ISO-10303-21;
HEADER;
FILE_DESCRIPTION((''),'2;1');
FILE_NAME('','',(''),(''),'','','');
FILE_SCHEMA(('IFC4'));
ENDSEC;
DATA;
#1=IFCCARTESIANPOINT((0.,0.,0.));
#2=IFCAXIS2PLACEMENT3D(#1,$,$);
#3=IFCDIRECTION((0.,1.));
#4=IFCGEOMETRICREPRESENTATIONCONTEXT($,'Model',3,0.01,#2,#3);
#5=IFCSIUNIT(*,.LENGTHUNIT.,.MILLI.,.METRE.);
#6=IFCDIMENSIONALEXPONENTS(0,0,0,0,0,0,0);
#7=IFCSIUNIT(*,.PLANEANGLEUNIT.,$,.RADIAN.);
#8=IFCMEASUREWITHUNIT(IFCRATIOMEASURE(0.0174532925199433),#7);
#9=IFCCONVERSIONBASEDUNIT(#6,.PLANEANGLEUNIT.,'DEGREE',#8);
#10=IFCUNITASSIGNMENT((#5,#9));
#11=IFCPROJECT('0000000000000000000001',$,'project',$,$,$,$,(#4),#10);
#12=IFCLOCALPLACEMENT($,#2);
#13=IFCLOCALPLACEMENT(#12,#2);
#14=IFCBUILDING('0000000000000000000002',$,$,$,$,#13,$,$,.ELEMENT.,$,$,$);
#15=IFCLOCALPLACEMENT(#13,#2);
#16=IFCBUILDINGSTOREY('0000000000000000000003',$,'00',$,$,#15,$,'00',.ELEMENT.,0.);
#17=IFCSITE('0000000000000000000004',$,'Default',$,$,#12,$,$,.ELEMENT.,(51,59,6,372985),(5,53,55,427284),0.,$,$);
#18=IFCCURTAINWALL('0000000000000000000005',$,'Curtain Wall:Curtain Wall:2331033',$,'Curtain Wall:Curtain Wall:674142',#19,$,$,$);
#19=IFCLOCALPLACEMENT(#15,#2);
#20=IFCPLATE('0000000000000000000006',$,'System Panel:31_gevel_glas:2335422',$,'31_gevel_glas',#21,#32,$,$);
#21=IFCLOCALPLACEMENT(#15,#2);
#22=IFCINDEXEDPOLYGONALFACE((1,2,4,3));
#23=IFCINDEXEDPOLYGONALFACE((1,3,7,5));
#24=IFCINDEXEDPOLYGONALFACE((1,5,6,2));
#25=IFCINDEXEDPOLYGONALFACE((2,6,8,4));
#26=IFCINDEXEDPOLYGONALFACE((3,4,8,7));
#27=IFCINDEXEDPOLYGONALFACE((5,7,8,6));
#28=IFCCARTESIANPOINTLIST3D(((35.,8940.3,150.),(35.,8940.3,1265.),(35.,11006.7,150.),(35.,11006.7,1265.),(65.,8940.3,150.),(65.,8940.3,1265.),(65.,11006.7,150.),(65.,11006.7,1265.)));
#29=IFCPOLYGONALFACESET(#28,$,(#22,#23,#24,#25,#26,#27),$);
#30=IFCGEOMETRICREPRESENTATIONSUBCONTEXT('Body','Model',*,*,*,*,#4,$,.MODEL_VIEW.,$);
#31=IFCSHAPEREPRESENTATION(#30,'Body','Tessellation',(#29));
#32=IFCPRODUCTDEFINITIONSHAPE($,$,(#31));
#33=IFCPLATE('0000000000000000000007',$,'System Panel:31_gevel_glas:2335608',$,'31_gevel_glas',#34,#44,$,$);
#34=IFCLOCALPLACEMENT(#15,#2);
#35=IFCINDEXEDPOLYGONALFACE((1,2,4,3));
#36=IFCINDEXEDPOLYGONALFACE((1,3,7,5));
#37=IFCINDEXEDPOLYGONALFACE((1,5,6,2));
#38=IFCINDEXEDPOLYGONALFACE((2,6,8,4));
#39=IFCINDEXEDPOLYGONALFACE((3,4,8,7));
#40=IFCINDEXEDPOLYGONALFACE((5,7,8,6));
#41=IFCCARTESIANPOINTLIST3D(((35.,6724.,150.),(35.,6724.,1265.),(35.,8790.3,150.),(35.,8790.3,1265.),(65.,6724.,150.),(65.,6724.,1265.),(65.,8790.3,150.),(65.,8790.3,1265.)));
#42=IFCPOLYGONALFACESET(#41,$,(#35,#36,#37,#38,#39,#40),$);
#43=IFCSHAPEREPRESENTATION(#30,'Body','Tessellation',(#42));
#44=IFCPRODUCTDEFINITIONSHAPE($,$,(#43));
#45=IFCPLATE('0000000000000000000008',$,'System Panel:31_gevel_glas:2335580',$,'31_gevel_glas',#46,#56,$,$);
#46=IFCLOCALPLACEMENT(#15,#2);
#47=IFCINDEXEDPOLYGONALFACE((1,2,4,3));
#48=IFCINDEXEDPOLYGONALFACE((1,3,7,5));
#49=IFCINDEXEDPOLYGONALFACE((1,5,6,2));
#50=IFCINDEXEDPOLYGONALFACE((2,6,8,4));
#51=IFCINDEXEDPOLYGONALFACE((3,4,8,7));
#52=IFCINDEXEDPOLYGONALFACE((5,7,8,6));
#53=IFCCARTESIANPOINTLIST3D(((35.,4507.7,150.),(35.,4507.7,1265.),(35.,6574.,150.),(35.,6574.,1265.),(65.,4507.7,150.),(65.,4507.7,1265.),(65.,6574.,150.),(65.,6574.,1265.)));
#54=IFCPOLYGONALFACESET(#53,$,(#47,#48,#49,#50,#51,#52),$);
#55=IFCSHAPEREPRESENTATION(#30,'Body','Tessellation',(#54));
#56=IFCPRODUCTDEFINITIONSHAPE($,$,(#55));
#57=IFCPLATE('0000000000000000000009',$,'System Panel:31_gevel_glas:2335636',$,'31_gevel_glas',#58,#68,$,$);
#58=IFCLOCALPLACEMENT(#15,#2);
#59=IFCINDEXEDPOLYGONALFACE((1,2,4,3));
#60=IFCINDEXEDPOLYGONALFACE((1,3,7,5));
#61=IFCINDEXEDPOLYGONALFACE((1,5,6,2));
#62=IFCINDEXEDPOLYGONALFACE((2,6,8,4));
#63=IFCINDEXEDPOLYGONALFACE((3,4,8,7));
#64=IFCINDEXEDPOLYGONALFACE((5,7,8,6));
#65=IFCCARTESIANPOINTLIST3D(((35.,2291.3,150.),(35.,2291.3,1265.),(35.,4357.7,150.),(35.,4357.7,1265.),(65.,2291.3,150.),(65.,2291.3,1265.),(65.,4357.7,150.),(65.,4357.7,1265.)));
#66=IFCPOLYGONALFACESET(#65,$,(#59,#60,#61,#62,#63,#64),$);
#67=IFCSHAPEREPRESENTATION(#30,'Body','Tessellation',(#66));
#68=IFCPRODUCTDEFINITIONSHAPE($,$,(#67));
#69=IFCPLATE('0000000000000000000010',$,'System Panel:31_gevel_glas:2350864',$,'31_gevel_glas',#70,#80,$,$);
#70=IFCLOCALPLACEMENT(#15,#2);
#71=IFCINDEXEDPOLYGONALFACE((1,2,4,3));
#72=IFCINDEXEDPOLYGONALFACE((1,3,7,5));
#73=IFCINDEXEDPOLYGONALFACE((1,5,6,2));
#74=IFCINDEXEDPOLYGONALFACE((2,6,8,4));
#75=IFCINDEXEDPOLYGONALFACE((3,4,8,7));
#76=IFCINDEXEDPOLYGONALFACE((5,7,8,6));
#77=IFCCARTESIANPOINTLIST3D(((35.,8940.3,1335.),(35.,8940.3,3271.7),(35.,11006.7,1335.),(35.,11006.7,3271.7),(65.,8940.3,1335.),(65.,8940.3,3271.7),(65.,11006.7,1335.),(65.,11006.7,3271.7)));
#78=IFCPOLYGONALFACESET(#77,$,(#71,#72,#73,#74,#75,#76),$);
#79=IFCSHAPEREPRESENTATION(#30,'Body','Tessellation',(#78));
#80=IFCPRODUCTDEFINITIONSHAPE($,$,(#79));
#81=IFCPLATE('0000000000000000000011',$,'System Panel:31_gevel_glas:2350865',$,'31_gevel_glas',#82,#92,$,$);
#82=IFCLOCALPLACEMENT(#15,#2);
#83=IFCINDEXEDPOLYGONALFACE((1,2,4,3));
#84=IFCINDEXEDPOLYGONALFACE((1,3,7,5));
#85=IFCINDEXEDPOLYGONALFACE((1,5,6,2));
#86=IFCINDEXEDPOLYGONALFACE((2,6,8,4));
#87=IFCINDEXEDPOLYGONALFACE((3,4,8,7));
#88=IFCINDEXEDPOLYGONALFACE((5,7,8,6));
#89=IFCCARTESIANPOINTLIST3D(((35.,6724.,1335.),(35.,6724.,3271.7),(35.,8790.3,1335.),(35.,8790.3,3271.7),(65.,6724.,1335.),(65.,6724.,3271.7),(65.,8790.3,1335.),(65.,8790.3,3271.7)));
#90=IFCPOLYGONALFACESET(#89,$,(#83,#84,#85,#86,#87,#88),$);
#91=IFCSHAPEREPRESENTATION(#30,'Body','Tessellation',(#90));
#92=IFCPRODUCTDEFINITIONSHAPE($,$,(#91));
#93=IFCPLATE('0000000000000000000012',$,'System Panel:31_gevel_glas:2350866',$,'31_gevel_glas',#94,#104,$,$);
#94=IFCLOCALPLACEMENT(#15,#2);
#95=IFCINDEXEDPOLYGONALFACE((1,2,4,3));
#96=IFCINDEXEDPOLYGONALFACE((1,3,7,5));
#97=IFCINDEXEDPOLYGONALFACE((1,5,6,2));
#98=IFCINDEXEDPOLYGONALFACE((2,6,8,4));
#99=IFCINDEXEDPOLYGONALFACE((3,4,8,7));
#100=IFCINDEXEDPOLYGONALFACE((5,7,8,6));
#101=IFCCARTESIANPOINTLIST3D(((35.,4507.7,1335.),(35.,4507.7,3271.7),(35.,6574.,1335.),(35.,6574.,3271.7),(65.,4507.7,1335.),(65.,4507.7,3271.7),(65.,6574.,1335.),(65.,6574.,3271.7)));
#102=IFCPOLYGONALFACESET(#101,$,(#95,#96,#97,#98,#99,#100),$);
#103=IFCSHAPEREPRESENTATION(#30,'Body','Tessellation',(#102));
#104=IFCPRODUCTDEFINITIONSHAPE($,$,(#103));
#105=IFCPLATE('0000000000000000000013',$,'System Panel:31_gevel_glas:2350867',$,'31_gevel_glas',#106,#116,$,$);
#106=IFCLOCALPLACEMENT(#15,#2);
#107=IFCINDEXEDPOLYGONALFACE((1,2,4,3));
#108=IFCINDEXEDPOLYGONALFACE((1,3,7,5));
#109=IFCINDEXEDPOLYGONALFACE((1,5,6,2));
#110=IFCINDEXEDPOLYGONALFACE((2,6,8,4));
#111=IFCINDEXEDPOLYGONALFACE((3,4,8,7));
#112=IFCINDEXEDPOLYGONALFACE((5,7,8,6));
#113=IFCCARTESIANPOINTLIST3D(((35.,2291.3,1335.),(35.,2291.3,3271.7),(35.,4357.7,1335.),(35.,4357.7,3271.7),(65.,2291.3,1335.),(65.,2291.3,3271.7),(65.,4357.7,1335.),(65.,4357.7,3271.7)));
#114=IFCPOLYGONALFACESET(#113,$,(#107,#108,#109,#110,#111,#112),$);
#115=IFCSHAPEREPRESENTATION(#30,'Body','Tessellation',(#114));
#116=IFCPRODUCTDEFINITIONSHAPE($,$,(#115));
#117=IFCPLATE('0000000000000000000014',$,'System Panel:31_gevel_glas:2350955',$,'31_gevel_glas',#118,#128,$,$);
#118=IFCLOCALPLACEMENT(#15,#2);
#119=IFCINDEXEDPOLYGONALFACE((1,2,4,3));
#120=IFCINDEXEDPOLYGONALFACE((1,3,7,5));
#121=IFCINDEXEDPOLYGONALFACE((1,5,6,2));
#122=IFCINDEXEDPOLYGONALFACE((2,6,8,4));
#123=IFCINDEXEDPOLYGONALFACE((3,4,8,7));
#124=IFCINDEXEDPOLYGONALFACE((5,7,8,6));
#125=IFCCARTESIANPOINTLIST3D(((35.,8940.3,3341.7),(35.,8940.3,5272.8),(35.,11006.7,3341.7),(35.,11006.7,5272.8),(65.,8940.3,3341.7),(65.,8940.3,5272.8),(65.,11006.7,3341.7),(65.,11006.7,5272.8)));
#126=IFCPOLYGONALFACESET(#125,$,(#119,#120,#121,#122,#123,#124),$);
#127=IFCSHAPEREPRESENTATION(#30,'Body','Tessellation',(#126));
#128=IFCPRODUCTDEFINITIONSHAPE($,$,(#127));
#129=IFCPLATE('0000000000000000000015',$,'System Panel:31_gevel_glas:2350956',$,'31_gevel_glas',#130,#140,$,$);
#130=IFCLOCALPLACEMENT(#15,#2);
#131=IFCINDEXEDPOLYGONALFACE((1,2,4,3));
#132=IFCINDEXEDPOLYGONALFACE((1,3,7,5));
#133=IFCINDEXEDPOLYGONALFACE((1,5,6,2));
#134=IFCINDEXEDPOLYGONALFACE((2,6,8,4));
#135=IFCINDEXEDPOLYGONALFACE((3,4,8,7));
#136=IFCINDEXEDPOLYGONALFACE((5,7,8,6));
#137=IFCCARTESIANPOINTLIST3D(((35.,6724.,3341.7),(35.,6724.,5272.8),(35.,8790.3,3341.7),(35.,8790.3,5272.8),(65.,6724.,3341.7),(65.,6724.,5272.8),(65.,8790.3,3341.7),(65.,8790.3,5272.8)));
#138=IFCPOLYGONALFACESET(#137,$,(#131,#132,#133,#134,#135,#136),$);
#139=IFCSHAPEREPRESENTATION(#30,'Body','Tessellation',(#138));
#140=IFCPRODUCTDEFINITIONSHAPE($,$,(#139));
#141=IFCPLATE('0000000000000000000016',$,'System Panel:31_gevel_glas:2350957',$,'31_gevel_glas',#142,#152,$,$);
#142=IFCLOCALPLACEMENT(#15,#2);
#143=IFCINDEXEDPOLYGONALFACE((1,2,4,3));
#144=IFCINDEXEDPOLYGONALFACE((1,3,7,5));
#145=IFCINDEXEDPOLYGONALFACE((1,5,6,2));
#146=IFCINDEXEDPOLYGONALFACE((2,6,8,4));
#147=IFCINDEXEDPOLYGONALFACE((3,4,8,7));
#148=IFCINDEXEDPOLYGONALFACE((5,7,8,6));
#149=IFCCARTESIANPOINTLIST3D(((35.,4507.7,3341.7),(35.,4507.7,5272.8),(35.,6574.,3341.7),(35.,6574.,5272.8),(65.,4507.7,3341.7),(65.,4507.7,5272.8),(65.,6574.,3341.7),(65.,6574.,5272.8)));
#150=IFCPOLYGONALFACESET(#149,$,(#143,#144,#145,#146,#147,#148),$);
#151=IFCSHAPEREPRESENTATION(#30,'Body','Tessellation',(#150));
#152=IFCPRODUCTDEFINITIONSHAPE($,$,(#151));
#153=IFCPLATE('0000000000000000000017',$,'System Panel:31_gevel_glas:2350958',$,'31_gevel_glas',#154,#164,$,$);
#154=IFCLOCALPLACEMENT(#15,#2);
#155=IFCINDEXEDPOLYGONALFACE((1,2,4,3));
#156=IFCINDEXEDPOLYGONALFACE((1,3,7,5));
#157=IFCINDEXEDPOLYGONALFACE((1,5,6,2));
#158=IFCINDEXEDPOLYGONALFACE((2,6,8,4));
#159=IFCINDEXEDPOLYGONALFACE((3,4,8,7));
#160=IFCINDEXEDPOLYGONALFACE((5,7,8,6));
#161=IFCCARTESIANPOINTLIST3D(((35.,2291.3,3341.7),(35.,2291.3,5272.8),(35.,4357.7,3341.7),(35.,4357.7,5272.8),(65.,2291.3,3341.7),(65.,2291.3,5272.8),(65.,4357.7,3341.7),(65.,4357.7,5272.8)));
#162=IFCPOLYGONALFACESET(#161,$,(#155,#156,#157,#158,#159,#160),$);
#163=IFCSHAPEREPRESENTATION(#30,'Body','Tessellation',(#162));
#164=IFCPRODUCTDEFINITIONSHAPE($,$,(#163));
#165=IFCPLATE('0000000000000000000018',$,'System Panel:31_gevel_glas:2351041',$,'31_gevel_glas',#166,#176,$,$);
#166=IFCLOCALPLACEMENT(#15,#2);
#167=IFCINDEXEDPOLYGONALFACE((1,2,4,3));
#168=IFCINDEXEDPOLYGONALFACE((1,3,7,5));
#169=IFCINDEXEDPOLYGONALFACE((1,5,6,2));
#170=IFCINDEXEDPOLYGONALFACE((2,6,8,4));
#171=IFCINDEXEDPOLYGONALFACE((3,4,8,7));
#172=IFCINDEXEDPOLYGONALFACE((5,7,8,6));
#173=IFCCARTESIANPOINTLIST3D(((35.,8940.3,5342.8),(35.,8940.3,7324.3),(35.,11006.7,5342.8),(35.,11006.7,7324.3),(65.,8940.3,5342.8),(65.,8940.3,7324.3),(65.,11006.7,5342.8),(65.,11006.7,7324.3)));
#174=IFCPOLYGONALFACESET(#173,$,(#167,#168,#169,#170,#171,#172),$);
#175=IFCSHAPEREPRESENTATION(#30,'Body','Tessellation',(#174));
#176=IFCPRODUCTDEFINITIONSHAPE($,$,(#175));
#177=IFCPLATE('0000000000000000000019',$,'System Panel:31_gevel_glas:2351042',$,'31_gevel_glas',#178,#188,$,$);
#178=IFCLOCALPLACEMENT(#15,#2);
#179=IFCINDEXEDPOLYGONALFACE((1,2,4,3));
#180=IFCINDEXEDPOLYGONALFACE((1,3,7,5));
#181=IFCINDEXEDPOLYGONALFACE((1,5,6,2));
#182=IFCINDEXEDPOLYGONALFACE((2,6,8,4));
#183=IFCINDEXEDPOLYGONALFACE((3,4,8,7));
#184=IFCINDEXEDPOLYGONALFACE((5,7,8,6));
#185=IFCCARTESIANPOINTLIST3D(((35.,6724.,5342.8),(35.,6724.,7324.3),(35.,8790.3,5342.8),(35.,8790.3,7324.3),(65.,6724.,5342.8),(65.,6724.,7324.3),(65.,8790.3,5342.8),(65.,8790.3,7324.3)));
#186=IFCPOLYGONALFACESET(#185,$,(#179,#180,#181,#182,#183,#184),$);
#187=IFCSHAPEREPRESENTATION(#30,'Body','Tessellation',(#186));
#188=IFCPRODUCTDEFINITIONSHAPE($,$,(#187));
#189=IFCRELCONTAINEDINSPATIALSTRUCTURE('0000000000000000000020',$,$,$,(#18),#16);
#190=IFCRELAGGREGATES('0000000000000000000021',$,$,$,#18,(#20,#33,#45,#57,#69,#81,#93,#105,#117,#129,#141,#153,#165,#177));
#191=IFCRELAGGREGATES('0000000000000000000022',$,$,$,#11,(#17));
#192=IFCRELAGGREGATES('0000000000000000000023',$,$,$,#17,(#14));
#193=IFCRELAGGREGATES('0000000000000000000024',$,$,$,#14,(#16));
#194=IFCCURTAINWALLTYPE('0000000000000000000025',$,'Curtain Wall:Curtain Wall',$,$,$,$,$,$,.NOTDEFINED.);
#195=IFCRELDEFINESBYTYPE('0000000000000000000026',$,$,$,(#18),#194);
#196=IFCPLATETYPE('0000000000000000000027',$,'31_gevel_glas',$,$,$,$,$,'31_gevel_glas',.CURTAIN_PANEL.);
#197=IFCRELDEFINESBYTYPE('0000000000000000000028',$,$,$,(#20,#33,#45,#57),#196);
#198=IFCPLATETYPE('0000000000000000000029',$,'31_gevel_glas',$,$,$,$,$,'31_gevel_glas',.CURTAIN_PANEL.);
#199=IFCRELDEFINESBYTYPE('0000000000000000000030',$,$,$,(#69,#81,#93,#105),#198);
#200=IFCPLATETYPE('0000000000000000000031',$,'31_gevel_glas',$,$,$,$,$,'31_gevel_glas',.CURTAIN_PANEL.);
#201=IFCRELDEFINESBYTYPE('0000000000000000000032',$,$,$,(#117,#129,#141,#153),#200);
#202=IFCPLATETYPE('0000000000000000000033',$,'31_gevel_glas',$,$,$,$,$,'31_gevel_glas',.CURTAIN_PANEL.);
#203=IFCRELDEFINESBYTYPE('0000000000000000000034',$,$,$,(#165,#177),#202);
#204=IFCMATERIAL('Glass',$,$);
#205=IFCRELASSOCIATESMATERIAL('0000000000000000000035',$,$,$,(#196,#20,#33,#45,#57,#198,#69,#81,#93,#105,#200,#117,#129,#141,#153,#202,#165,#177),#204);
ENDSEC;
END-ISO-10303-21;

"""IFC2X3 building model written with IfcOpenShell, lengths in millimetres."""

from ifc_helpers import new_model, entity, si_unit, converted_unit, direction, frame, origin, origin_2d_with_axis, place, context, subcontext, project, spatial, rectangle, extrude, source, transform, mapped, material, type_object, type_shapes, element, aggregate, save


model = new_model("IFC2X3")

# Units and contexts
model_context = context("Model", 3, precision=0.01, world=origin(), true_north=direction((0.0, 1.0)))
body_context = subcontext(model_context, "Body", "Model", "MODEL_VIEW")
ifc_project = project(units=[si_unit("LENGTHUNIT", "METRE", prefix="MILLI"), converted_unit("PLANEANGLEUNIT", "DEGREE", entity("IfcRatioMeasure", 0.0174532925199433), si_unit("PLANEANGLEUNIT", "RADIAN"), dimensions=[0, 0, 0, 0, 0, 0, 0])], contexts=[model_context])

# Site, building, storey
site_placement = place(None, origin())
site = spatial("IfcSite", under=ifc_project, at=site_placement, Name="Default", CompositionType="ELEMENT", RefLatitude=(51, 59, 6, 372985), RefLongitude=(5, 53, 55, 427284), RefElevation=0.0)
building_placement = place(site_placement, origin())
building = spatial("IfcBuilding", under=site, at=building_placement, CompositionType="ELEMENT")
storey_placement = place(building_placement, origin())
storey = spatial("IfcBuildingStorey", under=building, at=storey_placement, Name="00", LongName="00", CompositionType="ELEMENT", Elevation=0.0)

# Curtain wall, plates
curtain_wall_type = type_object("IfcCurtainWallType", Name="Curtain Wall:Curtain Wall", PredefinedType="NOTDEFINED")
curtain_wall_placement = place(storey_placement, origin())
curtain_wall = element("IfcCurtainWall", 1, at=curtain_wall_placement, inside=storey, type_object=curtain_wall_type, Name="Curtain Wall:Curtain Wall:2331033", ObjectType="Curtain Wall:Curtain Wall:674142")
ifc_material_1 = material(Name="Glass")
plate_type_1 = type_object("IfcPlateType", Name="31_gevel_glas", ElementType="31_gevel_glas", PredefinedType="CURTAIN_PANEL", material=ifc_material_1)
shared_shape_1 = source(origin(), body_context, "Body", "SweptSolid", [
    extrude(rectangle(XDim=30.0, YDim=2066.3, at=origin_2d_with_axis()), frame((0.0, 50.0, 0.0), z_axis=(0.0, 0.0, 1.0), x_axis=(0.0, 1.0, 0.0)), (0.0, 0.0, 1.0), 1115.0),
])
type_shapes(plate_type_1, [shared_shape_1])
plate_1_placement = place(curtain_wall_placement, frame((0.0, 9973.5, 150.0), z_axis=(0.0, 0.0, 1.0), x_axis=(0.0, -1.0, 0.0)))
plate_1 = element("IfcPlate", 2, at=plate_1_placement, type_object=plate_type_1, material=ifc_material_1, Name="System Panel:31_gevel_glas:2335422", ObjectType="31_gevel_glas", context=body_context, shape_type="MappedRepresentation", body=[
    mapped(shared_shape_1, transform((0.0, 0.0, 0.0), scale=1.0)),
])
plate_2_placement = place(curtain_wall_placement, frame((0.0, 7757.2, 150.0), z_axis=(0.0, 0.0, 1.0), x_axis=(0.0, -1.0, 0.0)))
plate_2 = element("IfcPlate", 3, at=plate_2_placement, type_object=plate_type_1, material=ifc_material_1, Name="System Panel:31_gevel_glas:2335608", ObjectType="31_gevel_glas", context=body_context, shape_type="MappedRepresentation", body=[
    mapped(shared_shape_1, transform((0.0, 0.0, 0.0), scale=1.0)),
])
plate_3_placement = place(curtain_wall_placement, frame((0.0, 5540.8, 150.0), z_axis=(0.0, 0.0, 1.0), x_axis=(0.0, -1.0, 0.0)))
plate_3 = element("IfcPlate", 4, at=plate_3_placement, type_object=plate_type_1, material=ifc_material_1, Name="System Panel:31_gevel_glas:2335580", ObjectType="31_gevel_glas", context=body_context, shape_type="MappedRepresentation", body=[
    mapped(shared_shape_1, transform((0.0, 0.0, 0.0), scale=1.0)),
])
plate_4_placement = place(curtain_wall_placement, frame((0.0, 3324.5, 150.0), z_axis=(0.0, 0.0, 1.0), x_axis=(0.0, -1.0, 0.0)))
plate_4 = element("IfcPlate", 5, at=plate_4_placement, type_object=plate_type_1, material=ifc_material_1, Name="System Panel:31_gevel_glas:2335636", ObjectType="31_gevel_glas", context=body_context, shape_type="MappedRepresentation", body=[
    mapped(shared_shape_1, transform((0.0, 0.0, 0.0), scale=1.0)),
])
plate_type_2 = type_object("IfcPlateType", Name="31_gevel_glas", ElementType="31_gevel_glas", PredefinedType="CURTAIN_PANEL", material=ifc_material_1)
shared_shape_2 = source(origin(), body_context, "Body", "SweptSolid", [
    extrude(rectangle(XDim=30.0, YDim=2066.3, at=origin_2d_with_axis()), frame((0.0, 50.0, 0.0), z_axis=(0.0, 0.0, 1.0), x_axis=(0.0, 1.0, 0.0)), (0.0, 0.0, 1.0), 1936.7),
])
type_shapes(plate_type_2, [shared_shape_2])
plate_5_placement = place(curtain_wall_placement, frame((0.0, 9973.5, 1335.0), z_axis=(0.0, 0.0, 1.0), x_axis=(0.0, -1.0, 0.0)))
plate_5 = element("IfcPlate", 6, at=plate_5_placement, type_object=plate_type_2, material=ifc_material_1, Name="System Panel:31_gevel_glas:2350864", ObjectType="31_gevel_glas", context=body_context, shape_type="MappedRepresentation", body=[
    mapped(shared_shape_2, transform((0.0, 0.0, 0.0), scale=1.0)),
])
plate_6_placement = place(curtain_wall_placement, frame((0.0, 7757.2, 1335.0), z_axis=(0.0, 0.0, 1.0), x_axis=(0.0, -1.0, 0.0)))
plate_6 = element("IfcPlate", 7, at=plate_6_placement, type_object=plate_type_2, material=ifc_material_1, Name="System Panel:31_gevel_glas:2350865", ObjectType="31_gevel_glas", context=body_context, shape_type="MappedRepresentation", body=[
    mapped(shared_shape_2, transform((0.0, 0.0, 0.0), scale=1.0)),
])
plate_7_placement = place(curtain_wall_placement, frame((0.0, 5540.8, 1335.0), z_axis=(0.0, 0.0, 1.0), x_axis=(0.0, -1.0, 0.0)))
plate_7 = element("IfcPlate", 8, at=plate_7_placement, type_object=plate_type_2, material=ifc_material_1, Name="System Panel:31_gevel_glas:2350866", ObjectType="31_gevel_glas", context=body_context, shape_type="MappedRepresentation", body=[
    mapped(shared_shape_2, transform((0.0, 0.0, 0.0), scale=1.0)),
])
plate_8_placement = place(curtain_wall_placement, frame((0.0, 3324.5, 1335.0), z_axis=(0.0, 0.0, 1.0), x_axis=(0.0, -1.0, 0.0)))
plate_8 = element("IfcPlate", 9, at=plate_8_placement, type_object=plate_type_2, material=ifc_material_1, Name="System Panel:31_gevel_glas:2350867", ObjectType="31_gevel_glas", context=body_context, shape_type="MappedRepresentation", body=[
    mapped(shared_shape_2, transform((0.0, 0.0, 0.0), scale=1.0)),
])
plate_type_3 = type_object("IfcPlateType", Name="31_gevel_glas", ElementType="31_gevel_glas", PredefinedType="CURTAIN_PANEL", material=ifc_material_1)
shared_shape_3 = source(origin(), body_context, "Body", "SweptSolid", [
    extrude(rectangle(XDim=30.0, YDim=2066.3, at=origin_2d_with_axis()), frame((0.0, 50.0, 0.0), z_axis=(0.0, 0.0, 1.0), x_axis=(0.0, 1.0, 0.0)), (0.0, 0.0, 1.0), 1931.1),
])
type_shapes(plate_type_3, [shared_shape_3])
plate_9_placement = place(curtain_wall_placement, frame((0.0, 9973.5, 3341.7), z_axis=(0.0, 0.0, 1.0), x_axis=(0.0, -1.0, 0.0)))
plate_9 = element("IfcPlate", 10, at=plate_9_placement, type_object=plate_type_3, material=ifc_material_1, Name="System Panel:31_gevel_glas:2350955", ObjectType="31_gevel_glas", context=body_context, shape_type="MappedRepresentation", body=[
    mapped(shared_shape_3, transform((0.0, 0.0, 0.0), scale=1.0)),
])
plate_10_placement = place(curtain_wall_placement, frame((0.0, 7757.2, 3341.7), z_axis=(0.0, 0.0, 1.0), x_axis=(0.0, -1.0, 0.0)))
plate_10 = element("IfcPlate", 11, at=plate_10_placement, type_object=plate_type_3, material=ifc_material_1, Name="System Panel:31_gevel_glas:2350956", ObjectType="31_gevel_glas", context=body_context, shape_type="MappedRepresentation", body=[
    mapped(shared_shape_3, transform((0.0, 0.0, 0.0), scale=1.0)),
])
plate_11_placement = place(curtain_wall_placement, frame((0.0, 5540.8, 3341.7), z_axis=(0.0, 0.0, 1.0), x_axis=(0.0, -1.0, 0.0)))
plate_11 = element("IfcPlate", 12, at=plate_11_placement, type_object=plate_type_3, material=ifc_material_1, Name="System Panel:31_gevel_glas:2350957", ObjectType="31_gevel_glas", context=body_context, shape_type="MappedRepresentation", body=[
    mapped(shared_shape_3, transform((0.0, 0.0, 0.0), scale=1.0)),
])
plate_12_placement = place(curtain_wall_placement, frame((0.0, 3324.5, 3341.7), z_axis=(0.0, 0.0, 1.0), x_axis=(0.0, -1.0, 0.0)))
plate_12 = element("IfcPlate", 13, at=plate_12_placement, type_object=plate_type_3, material=ifc_material_1, Name="System Panel:31_gevel_glas:2350958", ObjectType="31_gevel_glas", context=body_context, shape_type="MappedRepresentation", body=[
    mapped(shared_shape_3, transform((0.0, 0.0, 0.0), scale=1.0)),
])
plate_type_4 = type_object("IfcPlateType", Name="31_gevel_glas", ElementType="31_gevel_glas", PredefinedType="CURTAIN_PANEL", material=ifc_material_1)
shared_shape_4 = source(origin(), body_context, "Body", "SweptSolid", [
    extrude(rectangle(XDim=30.0, YDim=2066.3, at=origin_2d_with_axis()), frame((0.0, 50.0, 0.0), z_axis=(0.0, 0.0, 1.0), x_axis=(0.0, 1.0, 0.0)), (0.0, 0.0, 1.0), 1981.5),
])
type_shapes(plate_type_4, [shared_shape_4])
plate_13_placement = place(curtain_wall_placement, frame((0.0, 9973.5, 5342.8), z_axis=(0.0, 0.0, 1.0), x_axis=(0.0, -1.0, 0.0)))
plate_13 = element("IfcPlate", 14, at=plate_13_placement, type_object=plate_type_4, material=ifc_material_1, Name="System Panel:31_gevel_glas:2351041", ObjectType="31_gevel_glas", context=body_context, shape_type="MappedRepresentation", body=[
    mapped(shared_shape_4, transform((0.0, 0.0, 0.0), scale=1.0)),
])
plate_14_placement = place(curtain_wall_placement, frame((0.0, 7757.2, 5342.8), z_axis=(0.0, 0.0, 1.0), x_axis=(0.0, -1.0, 0.0)))
plate_14 = element("IfcPlate", 15, at=plate_14_placement, type_object=plate_type_4, material=ifc_material_1, Name="System Panel:31_gevel_glas:2351042", ObjectType="31_gevel_glas", context=body_context, shape_type="MappedRepresentation", body=[
    mapped(shared_shape_4, transform((0.0, 0.0, 0.0), scale=1.0)),
])
aggregate(curtain_wall, [plate_1, plate_2, plate_3, plate_4, plate_5, plate_6, plate_7, plate_8, plate_9, plate_10, plate_11, plate_12, plate_13, plate_14])

save(model, "model.ifc")
